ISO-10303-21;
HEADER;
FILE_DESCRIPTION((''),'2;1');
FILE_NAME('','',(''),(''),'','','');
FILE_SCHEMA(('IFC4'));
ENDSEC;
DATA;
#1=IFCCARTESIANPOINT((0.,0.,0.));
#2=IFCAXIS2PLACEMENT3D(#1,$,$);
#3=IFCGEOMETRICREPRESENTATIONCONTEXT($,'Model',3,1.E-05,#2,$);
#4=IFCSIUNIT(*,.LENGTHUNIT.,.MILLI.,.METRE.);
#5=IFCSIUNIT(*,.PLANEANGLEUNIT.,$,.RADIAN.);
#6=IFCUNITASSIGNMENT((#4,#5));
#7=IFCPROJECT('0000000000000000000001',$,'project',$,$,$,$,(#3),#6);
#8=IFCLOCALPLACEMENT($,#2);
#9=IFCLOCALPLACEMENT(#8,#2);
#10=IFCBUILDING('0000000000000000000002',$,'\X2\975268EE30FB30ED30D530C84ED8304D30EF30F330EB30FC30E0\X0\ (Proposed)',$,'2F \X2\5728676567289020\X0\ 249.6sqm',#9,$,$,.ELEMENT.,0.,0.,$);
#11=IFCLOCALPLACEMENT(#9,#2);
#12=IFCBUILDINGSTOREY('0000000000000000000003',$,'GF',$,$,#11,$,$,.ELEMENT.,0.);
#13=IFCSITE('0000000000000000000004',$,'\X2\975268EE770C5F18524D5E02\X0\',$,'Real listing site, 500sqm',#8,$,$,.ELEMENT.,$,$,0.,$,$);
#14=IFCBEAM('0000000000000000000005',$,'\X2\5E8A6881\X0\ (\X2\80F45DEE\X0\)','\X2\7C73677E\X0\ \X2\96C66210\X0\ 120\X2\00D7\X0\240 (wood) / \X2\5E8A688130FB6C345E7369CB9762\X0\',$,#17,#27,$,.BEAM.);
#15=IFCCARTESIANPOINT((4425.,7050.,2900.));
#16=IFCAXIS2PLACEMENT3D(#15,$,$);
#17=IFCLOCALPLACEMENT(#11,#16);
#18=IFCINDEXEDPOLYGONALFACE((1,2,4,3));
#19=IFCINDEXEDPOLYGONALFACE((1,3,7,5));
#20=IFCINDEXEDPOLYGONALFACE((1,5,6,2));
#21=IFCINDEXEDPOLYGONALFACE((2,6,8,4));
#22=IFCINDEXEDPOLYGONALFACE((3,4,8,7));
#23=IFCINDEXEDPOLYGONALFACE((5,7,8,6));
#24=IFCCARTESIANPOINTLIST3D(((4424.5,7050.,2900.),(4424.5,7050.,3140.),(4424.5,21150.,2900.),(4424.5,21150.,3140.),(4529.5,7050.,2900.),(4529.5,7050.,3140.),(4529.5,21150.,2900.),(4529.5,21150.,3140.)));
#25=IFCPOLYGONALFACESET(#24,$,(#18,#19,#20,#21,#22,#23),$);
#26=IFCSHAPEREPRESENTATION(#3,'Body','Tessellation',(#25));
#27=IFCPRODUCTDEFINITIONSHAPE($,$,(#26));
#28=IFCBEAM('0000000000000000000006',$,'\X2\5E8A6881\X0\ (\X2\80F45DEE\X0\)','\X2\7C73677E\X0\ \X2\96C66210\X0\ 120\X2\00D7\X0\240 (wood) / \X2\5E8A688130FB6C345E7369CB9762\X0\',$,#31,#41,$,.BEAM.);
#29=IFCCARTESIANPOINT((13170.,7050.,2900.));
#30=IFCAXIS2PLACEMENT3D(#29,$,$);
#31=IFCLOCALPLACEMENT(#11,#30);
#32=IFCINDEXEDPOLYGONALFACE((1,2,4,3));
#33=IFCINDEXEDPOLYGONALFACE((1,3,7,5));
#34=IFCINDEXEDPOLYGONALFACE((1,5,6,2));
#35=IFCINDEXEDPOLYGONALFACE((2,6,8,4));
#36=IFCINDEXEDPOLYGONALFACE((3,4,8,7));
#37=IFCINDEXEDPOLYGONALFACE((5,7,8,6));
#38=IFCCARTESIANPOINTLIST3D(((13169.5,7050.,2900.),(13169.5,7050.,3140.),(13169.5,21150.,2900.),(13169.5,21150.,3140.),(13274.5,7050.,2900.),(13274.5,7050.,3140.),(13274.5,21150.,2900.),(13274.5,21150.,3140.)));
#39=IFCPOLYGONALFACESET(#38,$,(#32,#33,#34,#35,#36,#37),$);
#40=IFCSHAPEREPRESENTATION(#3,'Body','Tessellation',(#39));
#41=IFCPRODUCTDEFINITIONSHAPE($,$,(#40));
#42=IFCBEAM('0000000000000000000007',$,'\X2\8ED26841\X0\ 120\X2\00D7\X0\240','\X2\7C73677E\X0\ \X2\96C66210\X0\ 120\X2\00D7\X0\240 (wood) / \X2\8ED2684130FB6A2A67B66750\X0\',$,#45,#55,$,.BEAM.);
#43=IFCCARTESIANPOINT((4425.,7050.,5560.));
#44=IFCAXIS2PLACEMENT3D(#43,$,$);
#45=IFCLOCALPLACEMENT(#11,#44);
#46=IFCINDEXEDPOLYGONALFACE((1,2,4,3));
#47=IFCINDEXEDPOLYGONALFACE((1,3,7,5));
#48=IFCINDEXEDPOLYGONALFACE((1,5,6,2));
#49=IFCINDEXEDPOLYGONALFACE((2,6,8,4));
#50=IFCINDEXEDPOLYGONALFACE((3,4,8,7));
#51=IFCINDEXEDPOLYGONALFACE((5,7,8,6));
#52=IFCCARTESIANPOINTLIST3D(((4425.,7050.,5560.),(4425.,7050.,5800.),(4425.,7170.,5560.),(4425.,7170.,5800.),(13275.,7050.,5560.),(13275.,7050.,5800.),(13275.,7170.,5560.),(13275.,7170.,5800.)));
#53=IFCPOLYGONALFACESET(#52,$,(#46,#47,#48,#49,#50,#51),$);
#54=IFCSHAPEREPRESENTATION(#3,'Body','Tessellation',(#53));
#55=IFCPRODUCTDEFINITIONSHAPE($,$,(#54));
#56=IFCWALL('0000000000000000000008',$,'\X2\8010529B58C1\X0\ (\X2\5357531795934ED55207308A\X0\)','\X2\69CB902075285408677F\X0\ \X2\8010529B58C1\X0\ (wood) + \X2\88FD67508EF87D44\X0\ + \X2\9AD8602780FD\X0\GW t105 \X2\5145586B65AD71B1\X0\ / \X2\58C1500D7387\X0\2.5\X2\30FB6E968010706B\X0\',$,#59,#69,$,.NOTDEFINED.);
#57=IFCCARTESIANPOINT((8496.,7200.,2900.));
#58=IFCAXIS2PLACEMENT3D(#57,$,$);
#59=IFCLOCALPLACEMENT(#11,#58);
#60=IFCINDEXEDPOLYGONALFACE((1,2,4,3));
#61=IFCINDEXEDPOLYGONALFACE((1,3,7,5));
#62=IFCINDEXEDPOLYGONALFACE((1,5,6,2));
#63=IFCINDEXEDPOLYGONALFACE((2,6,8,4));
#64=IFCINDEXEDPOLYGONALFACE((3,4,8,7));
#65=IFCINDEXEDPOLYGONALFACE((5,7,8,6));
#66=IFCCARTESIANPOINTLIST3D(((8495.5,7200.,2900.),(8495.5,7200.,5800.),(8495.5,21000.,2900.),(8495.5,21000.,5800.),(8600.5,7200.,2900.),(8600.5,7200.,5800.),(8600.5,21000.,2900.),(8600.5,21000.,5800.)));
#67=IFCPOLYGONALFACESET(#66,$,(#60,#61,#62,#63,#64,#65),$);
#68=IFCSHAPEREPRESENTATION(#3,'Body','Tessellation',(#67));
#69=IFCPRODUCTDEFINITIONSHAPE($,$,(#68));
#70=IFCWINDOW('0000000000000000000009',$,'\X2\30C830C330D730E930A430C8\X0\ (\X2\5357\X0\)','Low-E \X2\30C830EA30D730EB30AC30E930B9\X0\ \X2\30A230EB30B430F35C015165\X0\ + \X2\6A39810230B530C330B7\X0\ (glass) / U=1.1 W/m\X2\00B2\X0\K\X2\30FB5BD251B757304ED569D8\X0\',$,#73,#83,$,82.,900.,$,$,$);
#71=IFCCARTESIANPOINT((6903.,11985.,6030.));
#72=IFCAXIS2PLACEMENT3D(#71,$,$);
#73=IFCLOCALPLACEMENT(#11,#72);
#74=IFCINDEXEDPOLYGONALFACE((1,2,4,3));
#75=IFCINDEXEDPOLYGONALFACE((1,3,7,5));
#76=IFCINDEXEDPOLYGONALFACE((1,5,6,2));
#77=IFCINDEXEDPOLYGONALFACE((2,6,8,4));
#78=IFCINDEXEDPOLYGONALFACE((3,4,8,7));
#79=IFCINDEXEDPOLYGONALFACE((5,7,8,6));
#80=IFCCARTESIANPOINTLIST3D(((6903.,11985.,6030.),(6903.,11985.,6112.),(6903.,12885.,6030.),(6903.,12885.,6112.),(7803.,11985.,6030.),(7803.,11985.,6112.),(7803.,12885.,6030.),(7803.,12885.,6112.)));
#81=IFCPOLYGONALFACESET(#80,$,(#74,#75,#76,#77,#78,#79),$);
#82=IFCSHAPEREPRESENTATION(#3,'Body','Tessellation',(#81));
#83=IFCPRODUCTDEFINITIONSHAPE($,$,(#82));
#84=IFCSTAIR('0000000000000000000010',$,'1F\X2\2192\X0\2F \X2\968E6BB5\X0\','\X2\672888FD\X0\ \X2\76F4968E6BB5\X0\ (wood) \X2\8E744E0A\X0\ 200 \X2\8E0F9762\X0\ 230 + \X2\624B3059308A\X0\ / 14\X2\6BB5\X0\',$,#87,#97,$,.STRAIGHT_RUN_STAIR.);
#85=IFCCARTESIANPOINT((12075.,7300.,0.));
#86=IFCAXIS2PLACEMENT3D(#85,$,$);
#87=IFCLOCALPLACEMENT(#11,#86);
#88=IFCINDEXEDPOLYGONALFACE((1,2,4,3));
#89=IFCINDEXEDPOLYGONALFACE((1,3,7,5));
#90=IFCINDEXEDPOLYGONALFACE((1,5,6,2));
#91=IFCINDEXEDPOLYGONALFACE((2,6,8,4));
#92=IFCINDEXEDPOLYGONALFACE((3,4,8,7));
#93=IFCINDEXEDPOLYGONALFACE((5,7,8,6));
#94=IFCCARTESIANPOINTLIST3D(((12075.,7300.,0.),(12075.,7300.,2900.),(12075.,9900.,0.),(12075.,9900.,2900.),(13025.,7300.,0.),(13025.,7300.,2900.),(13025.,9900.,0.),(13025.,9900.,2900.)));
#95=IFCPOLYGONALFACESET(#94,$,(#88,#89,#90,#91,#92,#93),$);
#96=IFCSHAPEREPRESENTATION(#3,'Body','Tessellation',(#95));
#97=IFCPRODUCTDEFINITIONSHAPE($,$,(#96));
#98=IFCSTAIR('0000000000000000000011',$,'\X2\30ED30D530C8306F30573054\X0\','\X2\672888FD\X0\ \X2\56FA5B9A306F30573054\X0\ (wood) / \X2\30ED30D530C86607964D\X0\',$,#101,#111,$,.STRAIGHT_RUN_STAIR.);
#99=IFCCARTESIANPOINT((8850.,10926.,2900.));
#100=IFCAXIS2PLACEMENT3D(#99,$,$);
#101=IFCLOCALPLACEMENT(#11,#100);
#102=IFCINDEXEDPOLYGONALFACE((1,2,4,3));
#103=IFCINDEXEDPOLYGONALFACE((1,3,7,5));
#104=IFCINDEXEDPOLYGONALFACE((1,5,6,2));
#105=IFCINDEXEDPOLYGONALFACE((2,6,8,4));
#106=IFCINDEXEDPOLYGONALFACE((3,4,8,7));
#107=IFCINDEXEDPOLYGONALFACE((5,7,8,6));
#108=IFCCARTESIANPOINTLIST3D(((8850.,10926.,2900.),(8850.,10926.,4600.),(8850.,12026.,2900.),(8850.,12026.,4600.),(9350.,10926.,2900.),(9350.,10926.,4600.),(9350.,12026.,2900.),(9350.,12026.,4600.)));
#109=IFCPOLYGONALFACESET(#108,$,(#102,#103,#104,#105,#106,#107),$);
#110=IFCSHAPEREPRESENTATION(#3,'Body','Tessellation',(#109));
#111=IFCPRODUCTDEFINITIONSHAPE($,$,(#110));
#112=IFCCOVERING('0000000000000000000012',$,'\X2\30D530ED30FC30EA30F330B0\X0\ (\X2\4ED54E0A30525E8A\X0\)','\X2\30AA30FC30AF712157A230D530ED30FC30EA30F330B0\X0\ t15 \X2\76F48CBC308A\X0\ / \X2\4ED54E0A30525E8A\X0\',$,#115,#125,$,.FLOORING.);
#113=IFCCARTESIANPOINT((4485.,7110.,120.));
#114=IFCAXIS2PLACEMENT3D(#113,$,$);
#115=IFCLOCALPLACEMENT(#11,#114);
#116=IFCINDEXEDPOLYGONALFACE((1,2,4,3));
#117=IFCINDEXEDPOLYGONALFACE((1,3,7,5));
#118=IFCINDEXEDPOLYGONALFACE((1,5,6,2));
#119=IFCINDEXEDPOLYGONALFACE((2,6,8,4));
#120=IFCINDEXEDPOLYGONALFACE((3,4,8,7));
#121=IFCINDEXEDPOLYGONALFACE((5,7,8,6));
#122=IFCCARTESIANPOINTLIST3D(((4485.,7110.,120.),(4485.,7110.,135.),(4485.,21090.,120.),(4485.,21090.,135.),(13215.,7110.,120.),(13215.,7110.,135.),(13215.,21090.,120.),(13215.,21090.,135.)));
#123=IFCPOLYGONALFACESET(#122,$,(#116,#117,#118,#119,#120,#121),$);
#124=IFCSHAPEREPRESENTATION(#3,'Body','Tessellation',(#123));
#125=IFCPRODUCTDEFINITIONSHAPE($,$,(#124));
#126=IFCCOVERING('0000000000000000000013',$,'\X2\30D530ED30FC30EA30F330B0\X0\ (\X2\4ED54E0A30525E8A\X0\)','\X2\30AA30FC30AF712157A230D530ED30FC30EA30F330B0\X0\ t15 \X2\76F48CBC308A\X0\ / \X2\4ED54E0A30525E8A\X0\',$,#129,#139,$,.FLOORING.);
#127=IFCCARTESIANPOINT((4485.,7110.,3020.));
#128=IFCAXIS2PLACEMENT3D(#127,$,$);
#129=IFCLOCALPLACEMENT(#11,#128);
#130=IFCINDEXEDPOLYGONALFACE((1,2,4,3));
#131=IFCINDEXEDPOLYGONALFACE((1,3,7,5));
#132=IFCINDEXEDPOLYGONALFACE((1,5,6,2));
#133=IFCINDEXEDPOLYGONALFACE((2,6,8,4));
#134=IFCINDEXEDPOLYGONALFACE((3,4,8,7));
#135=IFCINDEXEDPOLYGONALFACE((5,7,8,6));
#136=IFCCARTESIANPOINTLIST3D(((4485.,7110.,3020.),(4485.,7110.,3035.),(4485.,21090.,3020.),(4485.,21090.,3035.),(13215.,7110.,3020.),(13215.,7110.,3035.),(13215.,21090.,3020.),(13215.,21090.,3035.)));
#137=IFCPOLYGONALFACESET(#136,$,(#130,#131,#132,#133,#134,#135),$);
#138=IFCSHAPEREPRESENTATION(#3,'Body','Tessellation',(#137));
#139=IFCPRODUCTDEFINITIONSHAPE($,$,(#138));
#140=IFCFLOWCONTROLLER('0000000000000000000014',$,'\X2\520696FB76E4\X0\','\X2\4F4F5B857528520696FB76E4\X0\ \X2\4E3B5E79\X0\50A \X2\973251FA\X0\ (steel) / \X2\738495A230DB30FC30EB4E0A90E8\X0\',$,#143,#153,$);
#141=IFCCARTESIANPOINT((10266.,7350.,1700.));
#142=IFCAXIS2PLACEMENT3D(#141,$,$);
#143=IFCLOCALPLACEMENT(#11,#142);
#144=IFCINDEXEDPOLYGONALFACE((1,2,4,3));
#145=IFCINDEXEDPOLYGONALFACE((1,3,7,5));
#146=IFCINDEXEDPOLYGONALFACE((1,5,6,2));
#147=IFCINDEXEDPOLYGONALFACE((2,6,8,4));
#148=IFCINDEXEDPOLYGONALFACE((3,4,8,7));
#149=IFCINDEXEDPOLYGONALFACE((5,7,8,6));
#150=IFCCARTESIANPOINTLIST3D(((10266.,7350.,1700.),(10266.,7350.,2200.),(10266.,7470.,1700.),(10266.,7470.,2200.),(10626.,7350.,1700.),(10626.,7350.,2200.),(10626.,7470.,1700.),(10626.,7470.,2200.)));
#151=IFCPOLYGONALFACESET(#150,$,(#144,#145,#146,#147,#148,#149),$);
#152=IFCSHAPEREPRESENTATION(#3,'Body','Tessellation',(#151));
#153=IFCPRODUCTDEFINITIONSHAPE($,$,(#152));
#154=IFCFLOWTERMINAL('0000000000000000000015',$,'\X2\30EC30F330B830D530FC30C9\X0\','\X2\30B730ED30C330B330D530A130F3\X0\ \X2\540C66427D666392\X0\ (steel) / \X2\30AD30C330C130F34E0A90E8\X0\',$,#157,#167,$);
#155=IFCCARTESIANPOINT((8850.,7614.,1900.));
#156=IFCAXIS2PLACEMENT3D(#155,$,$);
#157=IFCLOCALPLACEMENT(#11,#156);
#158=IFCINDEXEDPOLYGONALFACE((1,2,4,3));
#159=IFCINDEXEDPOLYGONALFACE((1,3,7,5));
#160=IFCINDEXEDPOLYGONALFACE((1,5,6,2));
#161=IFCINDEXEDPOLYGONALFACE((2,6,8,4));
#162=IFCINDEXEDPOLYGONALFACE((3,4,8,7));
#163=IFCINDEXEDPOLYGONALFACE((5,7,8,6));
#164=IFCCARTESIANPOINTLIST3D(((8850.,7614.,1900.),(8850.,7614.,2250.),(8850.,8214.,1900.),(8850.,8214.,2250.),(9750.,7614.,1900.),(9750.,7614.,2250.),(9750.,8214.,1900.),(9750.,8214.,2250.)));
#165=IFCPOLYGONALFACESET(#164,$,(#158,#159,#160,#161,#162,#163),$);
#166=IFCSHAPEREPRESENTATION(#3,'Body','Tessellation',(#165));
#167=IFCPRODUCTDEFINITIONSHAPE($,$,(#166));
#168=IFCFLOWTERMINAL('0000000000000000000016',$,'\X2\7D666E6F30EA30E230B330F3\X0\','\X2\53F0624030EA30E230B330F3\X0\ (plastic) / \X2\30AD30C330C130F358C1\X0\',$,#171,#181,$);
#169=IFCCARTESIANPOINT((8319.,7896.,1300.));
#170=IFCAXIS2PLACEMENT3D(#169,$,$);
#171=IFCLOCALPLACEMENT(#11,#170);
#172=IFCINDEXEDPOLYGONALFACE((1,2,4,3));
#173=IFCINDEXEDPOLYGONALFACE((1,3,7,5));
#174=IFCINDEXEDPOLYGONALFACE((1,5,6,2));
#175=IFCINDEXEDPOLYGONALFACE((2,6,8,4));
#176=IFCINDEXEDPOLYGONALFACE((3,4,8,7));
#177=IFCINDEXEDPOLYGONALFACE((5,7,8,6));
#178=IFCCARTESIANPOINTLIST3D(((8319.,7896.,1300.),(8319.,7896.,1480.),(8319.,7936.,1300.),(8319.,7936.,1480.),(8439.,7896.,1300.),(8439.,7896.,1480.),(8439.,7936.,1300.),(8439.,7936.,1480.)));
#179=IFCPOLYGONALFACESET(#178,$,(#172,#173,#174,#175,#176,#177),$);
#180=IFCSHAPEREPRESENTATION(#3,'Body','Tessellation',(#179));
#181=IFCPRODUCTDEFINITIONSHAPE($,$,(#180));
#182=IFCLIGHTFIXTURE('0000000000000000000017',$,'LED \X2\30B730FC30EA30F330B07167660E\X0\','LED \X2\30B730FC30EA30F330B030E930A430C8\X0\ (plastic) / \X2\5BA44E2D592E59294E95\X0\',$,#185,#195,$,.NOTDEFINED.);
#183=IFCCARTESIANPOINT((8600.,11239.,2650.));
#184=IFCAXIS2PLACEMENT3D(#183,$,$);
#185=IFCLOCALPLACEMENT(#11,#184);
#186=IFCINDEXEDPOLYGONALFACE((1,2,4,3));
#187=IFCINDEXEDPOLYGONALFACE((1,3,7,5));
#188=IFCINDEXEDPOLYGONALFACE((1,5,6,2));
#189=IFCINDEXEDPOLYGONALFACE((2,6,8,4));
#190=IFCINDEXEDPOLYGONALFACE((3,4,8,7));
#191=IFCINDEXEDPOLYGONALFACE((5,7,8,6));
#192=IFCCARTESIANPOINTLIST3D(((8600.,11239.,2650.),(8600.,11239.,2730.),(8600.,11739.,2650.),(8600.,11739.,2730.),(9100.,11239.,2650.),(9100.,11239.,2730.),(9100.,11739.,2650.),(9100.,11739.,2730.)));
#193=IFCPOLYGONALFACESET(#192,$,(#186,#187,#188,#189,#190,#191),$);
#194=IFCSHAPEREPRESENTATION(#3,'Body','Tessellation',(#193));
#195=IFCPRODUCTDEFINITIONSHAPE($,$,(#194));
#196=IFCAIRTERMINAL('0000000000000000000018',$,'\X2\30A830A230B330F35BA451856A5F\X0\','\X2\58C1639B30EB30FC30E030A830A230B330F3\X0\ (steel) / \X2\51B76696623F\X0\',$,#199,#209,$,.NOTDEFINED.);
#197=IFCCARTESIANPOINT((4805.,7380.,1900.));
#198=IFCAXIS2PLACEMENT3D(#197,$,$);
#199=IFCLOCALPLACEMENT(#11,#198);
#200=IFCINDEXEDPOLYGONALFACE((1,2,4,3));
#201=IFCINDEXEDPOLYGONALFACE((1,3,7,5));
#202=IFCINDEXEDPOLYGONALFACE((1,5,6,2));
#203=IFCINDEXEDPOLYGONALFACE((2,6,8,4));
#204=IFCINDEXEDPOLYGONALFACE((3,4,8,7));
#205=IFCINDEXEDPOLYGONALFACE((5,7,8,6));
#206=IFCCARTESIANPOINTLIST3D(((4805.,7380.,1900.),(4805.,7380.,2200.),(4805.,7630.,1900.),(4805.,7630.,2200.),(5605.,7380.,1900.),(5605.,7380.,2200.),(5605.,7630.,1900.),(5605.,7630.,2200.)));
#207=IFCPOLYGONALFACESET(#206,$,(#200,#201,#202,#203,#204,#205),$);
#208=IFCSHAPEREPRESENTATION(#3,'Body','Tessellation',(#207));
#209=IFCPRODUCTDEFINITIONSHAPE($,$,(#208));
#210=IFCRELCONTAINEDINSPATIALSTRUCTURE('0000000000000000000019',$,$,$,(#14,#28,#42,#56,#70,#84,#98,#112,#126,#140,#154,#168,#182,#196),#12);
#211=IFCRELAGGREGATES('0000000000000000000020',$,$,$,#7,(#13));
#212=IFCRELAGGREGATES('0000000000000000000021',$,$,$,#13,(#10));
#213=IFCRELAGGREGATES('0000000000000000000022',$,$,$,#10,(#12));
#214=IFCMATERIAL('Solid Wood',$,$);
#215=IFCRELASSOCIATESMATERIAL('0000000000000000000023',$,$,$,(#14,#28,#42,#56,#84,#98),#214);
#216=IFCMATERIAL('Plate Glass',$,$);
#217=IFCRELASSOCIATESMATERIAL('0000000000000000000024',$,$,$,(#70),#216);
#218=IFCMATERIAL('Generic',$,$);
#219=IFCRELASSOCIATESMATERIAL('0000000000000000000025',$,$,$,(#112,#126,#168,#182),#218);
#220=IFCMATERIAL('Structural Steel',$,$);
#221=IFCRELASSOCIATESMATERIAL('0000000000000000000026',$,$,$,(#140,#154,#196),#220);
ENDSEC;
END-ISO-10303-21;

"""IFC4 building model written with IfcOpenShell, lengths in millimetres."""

from ifc_helpers import new_model, si_unit, frame, frame_2d, origin, place, context, project, spatial, rectangle, extrude, material, element, save


model = new_model("IFC4")

# Units and contexts
model_context = context("Model", 3, precision=1e-05, world=origin())
ifc_project = project(units=[si_unit("LENGTHUNIT", "METRE", prefix="MILLI"), si_unit("PLANEANGLEUNIT", "RADIAN")], contexts=[model_context])

# Site, building, storey
site_placement = place(None, origin())
site = spatial("IfcSite", under=ifc_project, at=site_placement, Name="青森県弘前市", ObjectType="Real listing site, 500sqm", CompositionType="ELEMENT", RefElevation=0.0)
building_placement = place(site_placement, origin())
building = spatial("IfcBuilding", under=site, at=building_placement, Name="青森・ロフト付きワンルーム (Proposed)", ObjectType="2F 在来木造 249.6sqm", CompositionType="ELEMENT", ElevationOfRefHeight=0.0, ElevationOfTerrain=0.0)
storey_placement = place(building_placement, origin())
storey = spatial("IfcBuildingStorey", under=building, at=storey_placement, Name="GF", CompositionType="ELEMENT", Elevation=0.0)

# Shared definitions
ifc_material_1 = material(Name="Solid Wood")

# Beams
beam_1_placement = place(storey_placement, frame((4425.0, 7050.0, 2900.0)))
element("IfcBeam", 1, at=beam_1_placement, inside=storey, material=ifc_material_1, Name="床梁 (胴差)", Description="米松 集成 120×240 (wood) / 床梁・水平構面", PredefinedType="BEAM", context=model_context, shape_type="SweptSolid", body=[
    extrude(rectangle(XDim=105.0, YDim=14100.0, at=frame_2d((52.0, 7050.0))), frame((4425.0, 7050.0, 2900.0)), (0.0, 0.0, 1.0), 240.0),
])
beam_2_placement = place(storey_placement, frame((13170.0, 7050.0, 2900.0)))
element("IfcBeam", 2, at=beam_2_placement, inside=storey, material=ifc_material_1, Name="床梁 (胴差)", Description="米松 集成 120×240 (wood) / 床梁・水平構面", PredefinedType="BEAM", context=model_context, shape_type="SweptSolid", body=[
    extrude(rectangle(XDim=105.0, YDim=14100.0, at=frame_2d((52.0, 7050.0))), frame((13170.0, 7050.0, 2900.0)), (0.0, 0.0, 1.0), 240.0),
])
beam_3_placement = place(storey_placement, frame((4425.0, 7050.0, 5560.0)))
element("IfcBeam", 3, at=beam_3_placement, inside=storey, material=ifc_material_1, Name="軒桁 120×240", Description="米松 集成 120×240 (wood) / 軒桁・横架材", PredefinedType="BEAM", context=model_context, shape_type="SweptSolid", body=[
    extrude(rectangle(XDim=8850.0, YDim=120.0, at=frame_2d((4425.0, 60.0))), frame((4425.0, 7050.0, 5560.0)), (0.0, 0.0, 1.0), 240.0),
])

# Wall
wall_1_placement = place(storey_placement, frame((8496.0, 7200.0, 2900.0)))
element("IfcWall", 4, at=wall_1_placement, inside=storey, material=ifc_material_1, Name="耐力壁 (南北間仕切り)", Description="構造用合板 耐力壁 (wood) + 製材軸組 + 高性能GW t105 充填断熱 / 壁倍率2.5・準耐火", PredefinedType="NOTDEFINED", context=model_context, shape_type="SweptSolid", body=[
    extrude(rectangle(XDim=105.0, YDim=13800.0, at=frame_2d((52.0, 6900.0))), frame((8496.0, 7200.0, 2900.0)), (0.0, 0.0, 1.0), 2900.0),
])

# Window
ifc_material_2 = material(Name="Plate Glass")
window_placement = place(storey_placement, frame((6903.0, 11985.0, 6030.0)))
element("IfcWindow", 5, at=window_placement, inside=storey, material=ifc_material_2, Name="トップライト (南)", Description="Low-E トリプルガラス アルゴン封入 + 樹脂サッシ (glass) / U=1.1 W/m²K・寒冷地仕様", OverallHeight=82.0, OverallWidth=900.0, context=model_context, shape_type="SweptSolid", body=[
    extrude(rectangle(XDim=900.0, YDim=900.0, at=frame_2d((450.0, 450.0))), frame((6903.0, 11985.0, 6030.0)), (0.0, 0.0, 1.0), 82.0),
])

# Stairs
stair_1_placement = place(storey_placement, frame((12075.0, 7300.0, 0.0)))
element("IfcStair", 6, at=stair_1_placement, inside=storey, material=ifc_material_1, Name="1F→2F 階段", Description="木製 直階段 (wood) 蹴上 200 踏面 230 + 手すり / 14段", PredefinedType="STRAIGHT_RUN_STAIR", context=model_context, shape_type="SweptSolid", body=[
    extrude(rectangle(XDim=950.0, YDim=2600.0, at=frame_2d((475.0, 1300.0))), frame((12075.0, 7300.0, 0.0)), (0.0, 0.0, 1.0), 2900.0),
])
stair_2_placement = place(storey_placement, frame((8850.0, 10926.0, 2900.0)))
element("IfcStair", 7, at=stair_2_placement, inside=storey, material=ifc_material_1, Name="ロフトはしご", Description="木製 固定はしご (wood) / ロフト昇降", PredefinedType="STRAIGHT_RUN_STAIR", context=model_context, shape_type="SweptSolid", body=[
    extrude(rectangle(XDim=500.0, YDim=1100.0, at=frame_2d((250.0, 550.0))), frame((8850.0, 10926.0, 2900.0)), (0.0, 0.0, 1.0), 1700.0),
])

# Coverings
ifc_material_3 = material(Name="Generic")
covering_1_placement = place(storey_placement, frame((4485.0, 7110.0, 120.0)))
element("IfcCovering", 8, at=covering_1_placement, inside=storey, material=ifc_material_3, Name="フローリング (仕上げ床)", Description="オーク無垢フローリング t15 直貼り / 仕上げ床", PredefinedType="FLOORING", context=model_context, shape_type="SweptSolid", body=[
    extrude(rectangle(XDim=8730.0, YDim=13980.0, at=frame_2d((4365.0, 6990.0))), frame((4485.0, 7110.0, 120.0)), (0.0, 0.0, 1.0), 15.0),
])
covering_2_placement = place(storey_placement, frame((4485.0, 7110.0, 3020.0)))
element("IfcCovering", 9, at=covering_2_placement, inside=storey, material=ifc_material_3, Name="フローリング (仕上げ床)", Description="オーク無垢フローリング t15 直貼り / 仕上げ床", PredefinedType="FLOORING", context=model_context, shape_type="SweptSolid", body=[
    extrude(rectangle(XDim=8730.0, YDim=13980.0, at=frame_2d((4365.0, 6990.0))), frame((4485.0, 7110.0, 3020.0)), (0.0, 0.0, 1.0), 15.0),
])

# Flow controller
ifc_material_4 = material(Name="Structural Steel")
flow_controller_placement = place(storey_placement, frame((10266.0, 7350.0, 1700.0)))
element("IfcFlowController", 10, at=flow_controller_placement, inside=storey, material=ifc_material_4, Name="分電盤", Description="住宅用分電盤 主幹50A 露出 (steel) / 玄関ホール上部", context=model_context, shape_type="SweptSolid", body=[
    extrude(rectangle(XDim=360.0, YDim=120.0, at=frame_2d((180.0, 60.0))), frame((10266.0, 7350.0, 1700.0)), (0.0, 0.0, 1.0), 500.0),
])

# Flow terminals
flow_terminal_1_placement = place(storey_placement, frame((8850.0, 7614.0, 1900.0)))
element("IfcFlowTerminal", 11, at=flow_terminal_1_placement, inside=storey, material=ifc_material_4, Name="レンジフード", Description="シロッコファン 同時給排 (steel) / キッチン上部", context=model_context, shape_type="SweptSolid", body=[
    extrude(rectangle(XDim=900.0, YDim=600.0, at=frame_2d((450.0, 300.0))), frame((8850.0, 7614.0, 1900.0)), (0.0, 0.0, 1.0), 350.0),
])
flow_terminal_2_placement = place(storey_placement, frame((8319.0, 7896.0, 1300.0)))
element("IfcFlowTerminal", 12, at=flow_terminal_2_placement, inside=storey, material=ifc_material_3, Name="給湯リモコン", Description="台所リモコン (plastic) / キッチン壁", context=model_context, shape_type="SweptSolid", body=[
    extrude(rectangle(XDim=120.0, YDim=40.0, at=frame_2d((60.0, 20.0))), frame((8319.0, 7896.0, 1300.0)), (0.0, 0.0, 1.0), 180.0),
])

# Light fixture
light_fixture_1_placement = place(storey_placement, frame((8600.0, 11239.0, 2650.0)))
element("IfcLightFixture", 13, at=light_fixture_1_placement, inside=storey, material=ifc_material_3, Name="LED シーリング照明", Description="LED シーリングライト (plastic) / 室中央天井", PredefinedType="NOTDEFINED", context=model_context, shape_type="SweptSolid", body=[
    extrude(rectangle(XDim=500.0, YDim=500.0, at=frame_2d((250.0, 250.0))), frame((8600.0, 11239.0, 2650.0)), (0.0, 0.0, 1.0), 80.0),
])

# Air terminal
air_terminal_1_placement = place(storey_placement, frame((4805.0, 7380.0, 1900.0)))
element("IfcAirTerminal", 14, at=air_terminal_1_placement, inside=storey, material=ifc_material_4, Name="エアコン室内機", Description="壁掛ルームエアコン (steel) / 冷暖房", PredefinedType="NOTDEFINED", context=model_context, shape_type="SweptSolid", body=[
    extrude(rectangle(XDim=800.0, YDim=250.0, at=frame_2d((400.0, 125.0))), frame((4805.0, 7380.0, 1900.0)), (0.0, 0.0, 1.0), 300.0),
])

save(model, "model.ifc")
